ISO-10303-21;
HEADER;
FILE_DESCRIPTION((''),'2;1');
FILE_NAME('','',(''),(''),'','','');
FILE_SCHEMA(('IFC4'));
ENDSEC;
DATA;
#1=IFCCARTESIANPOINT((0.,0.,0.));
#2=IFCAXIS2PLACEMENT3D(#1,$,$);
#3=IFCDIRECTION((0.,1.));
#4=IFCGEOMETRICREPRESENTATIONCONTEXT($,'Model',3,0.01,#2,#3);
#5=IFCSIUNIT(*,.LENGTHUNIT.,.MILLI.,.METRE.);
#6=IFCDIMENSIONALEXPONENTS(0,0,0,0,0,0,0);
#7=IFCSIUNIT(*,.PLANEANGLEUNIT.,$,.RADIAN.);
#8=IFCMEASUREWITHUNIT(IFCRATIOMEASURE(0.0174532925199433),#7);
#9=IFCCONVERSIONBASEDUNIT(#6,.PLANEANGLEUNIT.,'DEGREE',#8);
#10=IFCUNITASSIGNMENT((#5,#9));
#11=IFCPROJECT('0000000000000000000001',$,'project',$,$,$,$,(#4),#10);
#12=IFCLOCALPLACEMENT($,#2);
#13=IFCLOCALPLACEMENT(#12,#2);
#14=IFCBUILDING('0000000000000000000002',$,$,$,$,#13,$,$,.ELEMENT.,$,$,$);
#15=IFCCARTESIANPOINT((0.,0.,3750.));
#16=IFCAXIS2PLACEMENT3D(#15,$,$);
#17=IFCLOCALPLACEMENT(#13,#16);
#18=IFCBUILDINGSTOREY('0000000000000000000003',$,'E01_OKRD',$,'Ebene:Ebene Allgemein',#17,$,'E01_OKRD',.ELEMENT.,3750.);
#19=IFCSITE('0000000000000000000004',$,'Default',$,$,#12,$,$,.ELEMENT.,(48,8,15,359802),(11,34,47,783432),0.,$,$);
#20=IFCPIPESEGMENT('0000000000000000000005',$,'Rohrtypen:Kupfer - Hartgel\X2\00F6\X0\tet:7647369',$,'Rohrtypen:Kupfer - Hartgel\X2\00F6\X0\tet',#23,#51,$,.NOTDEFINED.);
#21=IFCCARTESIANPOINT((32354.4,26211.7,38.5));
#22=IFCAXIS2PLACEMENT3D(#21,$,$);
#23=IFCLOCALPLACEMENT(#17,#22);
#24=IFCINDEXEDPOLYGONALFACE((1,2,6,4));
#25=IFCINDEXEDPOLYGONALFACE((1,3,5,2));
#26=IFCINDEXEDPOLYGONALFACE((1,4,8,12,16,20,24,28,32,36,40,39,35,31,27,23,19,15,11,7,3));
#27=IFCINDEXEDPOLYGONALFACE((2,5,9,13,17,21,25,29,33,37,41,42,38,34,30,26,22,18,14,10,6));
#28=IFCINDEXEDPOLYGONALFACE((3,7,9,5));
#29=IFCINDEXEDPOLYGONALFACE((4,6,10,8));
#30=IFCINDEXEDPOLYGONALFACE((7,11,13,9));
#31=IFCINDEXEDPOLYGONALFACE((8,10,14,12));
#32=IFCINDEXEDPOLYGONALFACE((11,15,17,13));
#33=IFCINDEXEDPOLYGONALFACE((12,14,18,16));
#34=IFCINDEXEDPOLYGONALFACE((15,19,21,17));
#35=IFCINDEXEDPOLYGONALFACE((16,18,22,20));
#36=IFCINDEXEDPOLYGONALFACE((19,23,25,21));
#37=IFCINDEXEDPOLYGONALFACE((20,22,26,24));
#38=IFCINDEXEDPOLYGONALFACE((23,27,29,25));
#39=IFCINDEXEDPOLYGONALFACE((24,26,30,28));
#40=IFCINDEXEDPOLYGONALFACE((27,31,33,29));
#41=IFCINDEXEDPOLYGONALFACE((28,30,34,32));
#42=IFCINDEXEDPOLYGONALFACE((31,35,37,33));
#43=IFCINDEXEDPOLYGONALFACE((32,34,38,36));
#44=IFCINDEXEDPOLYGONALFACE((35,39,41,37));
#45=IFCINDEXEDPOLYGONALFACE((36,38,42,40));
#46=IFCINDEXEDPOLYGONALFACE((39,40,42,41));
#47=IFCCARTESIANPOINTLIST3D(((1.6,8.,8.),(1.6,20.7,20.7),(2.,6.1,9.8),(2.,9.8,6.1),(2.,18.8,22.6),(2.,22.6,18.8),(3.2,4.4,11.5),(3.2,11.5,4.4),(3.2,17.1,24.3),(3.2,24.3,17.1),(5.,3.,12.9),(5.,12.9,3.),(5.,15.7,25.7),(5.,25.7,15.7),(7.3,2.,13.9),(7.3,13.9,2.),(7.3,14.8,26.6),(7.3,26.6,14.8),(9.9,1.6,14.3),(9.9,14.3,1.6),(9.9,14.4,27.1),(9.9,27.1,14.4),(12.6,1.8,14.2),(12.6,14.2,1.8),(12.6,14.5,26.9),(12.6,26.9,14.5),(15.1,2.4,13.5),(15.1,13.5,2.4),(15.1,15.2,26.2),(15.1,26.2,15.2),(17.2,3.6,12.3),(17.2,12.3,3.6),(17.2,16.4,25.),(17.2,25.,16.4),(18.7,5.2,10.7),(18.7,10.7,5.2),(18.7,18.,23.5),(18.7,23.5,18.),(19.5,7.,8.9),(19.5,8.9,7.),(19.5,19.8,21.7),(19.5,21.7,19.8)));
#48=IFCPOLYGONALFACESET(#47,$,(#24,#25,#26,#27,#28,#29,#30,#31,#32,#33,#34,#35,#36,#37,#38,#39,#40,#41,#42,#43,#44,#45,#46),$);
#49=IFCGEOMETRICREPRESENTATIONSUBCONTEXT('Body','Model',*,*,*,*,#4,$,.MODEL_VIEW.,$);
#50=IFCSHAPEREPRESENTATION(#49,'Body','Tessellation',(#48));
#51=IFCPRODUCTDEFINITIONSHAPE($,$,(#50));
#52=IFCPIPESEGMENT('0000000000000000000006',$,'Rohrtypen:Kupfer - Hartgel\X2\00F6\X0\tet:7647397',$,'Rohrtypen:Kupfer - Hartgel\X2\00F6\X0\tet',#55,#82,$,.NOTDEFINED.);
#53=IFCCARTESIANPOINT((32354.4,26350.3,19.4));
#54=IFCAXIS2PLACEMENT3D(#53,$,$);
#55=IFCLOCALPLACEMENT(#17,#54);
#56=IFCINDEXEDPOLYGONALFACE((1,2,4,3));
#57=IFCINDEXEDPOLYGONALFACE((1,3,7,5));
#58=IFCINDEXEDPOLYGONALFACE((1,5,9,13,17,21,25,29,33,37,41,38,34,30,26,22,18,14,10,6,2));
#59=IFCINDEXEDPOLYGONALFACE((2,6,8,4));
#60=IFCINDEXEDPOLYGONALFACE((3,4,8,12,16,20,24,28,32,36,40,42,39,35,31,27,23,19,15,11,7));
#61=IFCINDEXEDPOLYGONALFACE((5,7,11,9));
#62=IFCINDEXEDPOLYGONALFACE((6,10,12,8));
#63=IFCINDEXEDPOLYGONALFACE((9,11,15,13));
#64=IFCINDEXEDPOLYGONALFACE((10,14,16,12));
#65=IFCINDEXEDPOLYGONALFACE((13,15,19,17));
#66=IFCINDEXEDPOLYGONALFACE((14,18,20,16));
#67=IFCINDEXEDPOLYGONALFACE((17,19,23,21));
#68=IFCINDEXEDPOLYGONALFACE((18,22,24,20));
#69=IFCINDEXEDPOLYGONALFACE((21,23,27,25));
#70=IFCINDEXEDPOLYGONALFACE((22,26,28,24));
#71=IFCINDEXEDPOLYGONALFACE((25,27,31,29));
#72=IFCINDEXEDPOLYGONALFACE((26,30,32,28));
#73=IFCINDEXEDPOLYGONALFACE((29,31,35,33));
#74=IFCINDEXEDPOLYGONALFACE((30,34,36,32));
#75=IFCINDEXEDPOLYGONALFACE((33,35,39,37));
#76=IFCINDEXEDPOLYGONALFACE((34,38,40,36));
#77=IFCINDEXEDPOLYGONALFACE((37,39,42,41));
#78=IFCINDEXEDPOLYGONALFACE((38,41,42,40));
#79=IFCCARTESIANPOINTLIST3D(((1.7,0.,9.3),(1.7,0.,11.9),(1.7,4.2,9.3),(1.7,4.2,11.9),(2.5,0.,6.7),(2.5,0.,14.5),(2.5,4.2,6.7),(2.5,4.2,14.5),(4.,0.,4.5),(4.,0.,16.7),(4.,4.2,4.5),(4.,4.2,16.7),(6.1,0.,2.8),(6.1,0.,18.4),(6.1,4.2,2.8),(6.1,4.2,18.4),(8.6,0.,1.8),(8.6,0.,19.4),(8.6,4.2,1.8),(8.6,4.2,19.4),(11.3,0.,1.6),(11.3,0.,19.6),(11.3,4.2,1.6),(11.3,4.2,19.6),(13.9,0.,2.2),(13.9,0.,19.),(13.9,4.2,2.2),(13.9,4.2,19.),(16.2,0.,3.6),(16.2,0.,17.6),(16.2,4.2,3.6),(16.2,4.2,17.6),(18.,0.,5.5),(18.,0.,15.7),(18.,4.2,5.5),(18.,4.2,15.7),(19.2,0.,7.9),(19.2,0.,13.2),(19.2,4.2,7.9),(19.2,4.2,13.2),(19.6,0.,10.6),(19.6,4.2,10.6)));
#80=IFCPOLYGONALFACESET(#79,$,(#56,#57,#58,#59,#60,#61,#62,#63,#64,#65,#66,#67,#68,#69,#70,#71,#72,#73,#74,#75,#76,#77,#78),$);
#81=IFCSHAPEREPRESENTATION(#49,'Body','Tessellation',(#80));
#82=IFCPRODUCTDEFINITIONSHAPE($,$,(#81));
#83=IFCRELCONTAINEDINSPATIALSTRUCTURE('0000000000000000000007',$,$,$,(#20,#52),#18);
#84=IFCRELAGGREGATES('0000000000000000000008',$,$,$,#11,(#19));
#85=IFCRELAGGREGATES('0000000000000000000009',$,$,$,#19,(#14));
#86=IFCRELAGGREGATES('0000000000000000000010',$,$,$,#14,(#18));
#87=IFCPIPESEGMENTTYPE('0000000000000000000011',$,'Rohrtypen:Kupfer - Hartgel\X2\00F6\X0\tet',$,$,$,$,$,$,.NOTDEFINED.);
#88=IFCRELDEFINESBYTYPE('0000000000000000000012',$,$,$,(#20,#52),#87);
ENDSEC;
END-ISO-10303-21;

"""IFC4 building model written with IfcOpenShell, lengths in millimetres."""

from ifc_helpers import new_model, entity, si_unit, converted_unit, direction, frame, origin, origin_2d_with_axis, place, context, subcontext, project, spatial, circle, extrude, type_object, element, save


model = new_model("IFC4")

# Units and contexts
model_context = context("Model", 3, precision=0.01, world=origin(), true_north=direction((0.0, 1.0)))
body_context = subcontext(model_context, "Body", "Model", "MODEL_VIEW")
ifc_project = project(units=[si_unit("LENGTHUNIT", "METRE", prefix="MILLI"), converted_unit("PLANEANGLEUNIT", "DEGREE", entity("IfcRatioMeasure", 0.0174532925199433), si_unit("PLANEANGLEUNIT", "RADIAN"), dimensions=[0, 0, 0, 0, 0, 0, 0])], contexts=[model_context])

# Site, building, storey
site_placement = place(None, origin())
site = spatial("IfcSite", under=ifc_project, at=site_placement, Name="Default", CompositionType="ELEMENT", RefLatitude=(48, 8, 15, 359802), RefLongitude=(11, 34, 47, 783432), RefElevation=0.0)
building_placement = place(site_placement, origin())
building = spatial("IfcBuilding", under=site, at=building_placement, CompositionType="ELEMENT")
storey_placement = place(building_placement, frame((0.0, 0.0, 3750.0)))
storey = spatial("IfcBuildingStorey", under=building, at=storey_placement, Name="E01_OKRD", ObjectType="Ebene:Ebene Allgemein", LongName="E01_OKRD", CompositionType="ELEMENT", Elevation=3750.0)

# Pipe segments
pipe_segment_type = type_object("IfcPipeSegmentType", Name="Rohrtypen:Kupfer - Hartgelötet", PredefinedType="NOTDEFINED")
pipe_segment_1_placement = place(storey_placement, frame((32354.4, 26211.7, 38.5)))
element("IfcPipeSegment", 1, at=pipe_segment_1_placement, inside=storey, type_object=pipe_segment_type, Name="Rohrtypen:Kupfer - Hartgelötet:7647369", ObjectType="Rohrtypen:Kupfer - Hartgelötet", PredefinedType="NOTDEFINED", context=body_context, shape_type="SweptSolid", body=[
    extrude(circle(Radius=9.0, at=origin_2d_with_axis()), frame((10.6, 8.0, 8.0), z_axis=(0.0, 0.707107, 0.707107), x_axis=(-1.0, 0.0, 0.0)), (0.0, 0.0, 1.0), 18.0),
])
pipe_segment_2_placement = place(storey_placement, frame((32354.4, 26350.3, 19.4)))
element("IfcPipeSegment", 2, at=pipe_segment_2_placement, inside=storey, type_object=pipe_segment_type, Name="Rohrtypen:Kupfer - Hartgelötet:7647397", ObjectType="Rohrtypen:Kupfer - Hartgelötet", PredefinedType="NOTDEFINED", context=body_context, shape_type="SweptSolid", body=[
    extrude(circle(Radius=9.0, at=origin_2d_with_axis()), frame((10.6, 0.0, 10.6), z_axis=(0.0, 1.0, 0.0), x_axis=(1.0, 0.0, 0.0)), (0.0, 0.0, 1.0), 4.2),
])

save(model, "model.ifc")
